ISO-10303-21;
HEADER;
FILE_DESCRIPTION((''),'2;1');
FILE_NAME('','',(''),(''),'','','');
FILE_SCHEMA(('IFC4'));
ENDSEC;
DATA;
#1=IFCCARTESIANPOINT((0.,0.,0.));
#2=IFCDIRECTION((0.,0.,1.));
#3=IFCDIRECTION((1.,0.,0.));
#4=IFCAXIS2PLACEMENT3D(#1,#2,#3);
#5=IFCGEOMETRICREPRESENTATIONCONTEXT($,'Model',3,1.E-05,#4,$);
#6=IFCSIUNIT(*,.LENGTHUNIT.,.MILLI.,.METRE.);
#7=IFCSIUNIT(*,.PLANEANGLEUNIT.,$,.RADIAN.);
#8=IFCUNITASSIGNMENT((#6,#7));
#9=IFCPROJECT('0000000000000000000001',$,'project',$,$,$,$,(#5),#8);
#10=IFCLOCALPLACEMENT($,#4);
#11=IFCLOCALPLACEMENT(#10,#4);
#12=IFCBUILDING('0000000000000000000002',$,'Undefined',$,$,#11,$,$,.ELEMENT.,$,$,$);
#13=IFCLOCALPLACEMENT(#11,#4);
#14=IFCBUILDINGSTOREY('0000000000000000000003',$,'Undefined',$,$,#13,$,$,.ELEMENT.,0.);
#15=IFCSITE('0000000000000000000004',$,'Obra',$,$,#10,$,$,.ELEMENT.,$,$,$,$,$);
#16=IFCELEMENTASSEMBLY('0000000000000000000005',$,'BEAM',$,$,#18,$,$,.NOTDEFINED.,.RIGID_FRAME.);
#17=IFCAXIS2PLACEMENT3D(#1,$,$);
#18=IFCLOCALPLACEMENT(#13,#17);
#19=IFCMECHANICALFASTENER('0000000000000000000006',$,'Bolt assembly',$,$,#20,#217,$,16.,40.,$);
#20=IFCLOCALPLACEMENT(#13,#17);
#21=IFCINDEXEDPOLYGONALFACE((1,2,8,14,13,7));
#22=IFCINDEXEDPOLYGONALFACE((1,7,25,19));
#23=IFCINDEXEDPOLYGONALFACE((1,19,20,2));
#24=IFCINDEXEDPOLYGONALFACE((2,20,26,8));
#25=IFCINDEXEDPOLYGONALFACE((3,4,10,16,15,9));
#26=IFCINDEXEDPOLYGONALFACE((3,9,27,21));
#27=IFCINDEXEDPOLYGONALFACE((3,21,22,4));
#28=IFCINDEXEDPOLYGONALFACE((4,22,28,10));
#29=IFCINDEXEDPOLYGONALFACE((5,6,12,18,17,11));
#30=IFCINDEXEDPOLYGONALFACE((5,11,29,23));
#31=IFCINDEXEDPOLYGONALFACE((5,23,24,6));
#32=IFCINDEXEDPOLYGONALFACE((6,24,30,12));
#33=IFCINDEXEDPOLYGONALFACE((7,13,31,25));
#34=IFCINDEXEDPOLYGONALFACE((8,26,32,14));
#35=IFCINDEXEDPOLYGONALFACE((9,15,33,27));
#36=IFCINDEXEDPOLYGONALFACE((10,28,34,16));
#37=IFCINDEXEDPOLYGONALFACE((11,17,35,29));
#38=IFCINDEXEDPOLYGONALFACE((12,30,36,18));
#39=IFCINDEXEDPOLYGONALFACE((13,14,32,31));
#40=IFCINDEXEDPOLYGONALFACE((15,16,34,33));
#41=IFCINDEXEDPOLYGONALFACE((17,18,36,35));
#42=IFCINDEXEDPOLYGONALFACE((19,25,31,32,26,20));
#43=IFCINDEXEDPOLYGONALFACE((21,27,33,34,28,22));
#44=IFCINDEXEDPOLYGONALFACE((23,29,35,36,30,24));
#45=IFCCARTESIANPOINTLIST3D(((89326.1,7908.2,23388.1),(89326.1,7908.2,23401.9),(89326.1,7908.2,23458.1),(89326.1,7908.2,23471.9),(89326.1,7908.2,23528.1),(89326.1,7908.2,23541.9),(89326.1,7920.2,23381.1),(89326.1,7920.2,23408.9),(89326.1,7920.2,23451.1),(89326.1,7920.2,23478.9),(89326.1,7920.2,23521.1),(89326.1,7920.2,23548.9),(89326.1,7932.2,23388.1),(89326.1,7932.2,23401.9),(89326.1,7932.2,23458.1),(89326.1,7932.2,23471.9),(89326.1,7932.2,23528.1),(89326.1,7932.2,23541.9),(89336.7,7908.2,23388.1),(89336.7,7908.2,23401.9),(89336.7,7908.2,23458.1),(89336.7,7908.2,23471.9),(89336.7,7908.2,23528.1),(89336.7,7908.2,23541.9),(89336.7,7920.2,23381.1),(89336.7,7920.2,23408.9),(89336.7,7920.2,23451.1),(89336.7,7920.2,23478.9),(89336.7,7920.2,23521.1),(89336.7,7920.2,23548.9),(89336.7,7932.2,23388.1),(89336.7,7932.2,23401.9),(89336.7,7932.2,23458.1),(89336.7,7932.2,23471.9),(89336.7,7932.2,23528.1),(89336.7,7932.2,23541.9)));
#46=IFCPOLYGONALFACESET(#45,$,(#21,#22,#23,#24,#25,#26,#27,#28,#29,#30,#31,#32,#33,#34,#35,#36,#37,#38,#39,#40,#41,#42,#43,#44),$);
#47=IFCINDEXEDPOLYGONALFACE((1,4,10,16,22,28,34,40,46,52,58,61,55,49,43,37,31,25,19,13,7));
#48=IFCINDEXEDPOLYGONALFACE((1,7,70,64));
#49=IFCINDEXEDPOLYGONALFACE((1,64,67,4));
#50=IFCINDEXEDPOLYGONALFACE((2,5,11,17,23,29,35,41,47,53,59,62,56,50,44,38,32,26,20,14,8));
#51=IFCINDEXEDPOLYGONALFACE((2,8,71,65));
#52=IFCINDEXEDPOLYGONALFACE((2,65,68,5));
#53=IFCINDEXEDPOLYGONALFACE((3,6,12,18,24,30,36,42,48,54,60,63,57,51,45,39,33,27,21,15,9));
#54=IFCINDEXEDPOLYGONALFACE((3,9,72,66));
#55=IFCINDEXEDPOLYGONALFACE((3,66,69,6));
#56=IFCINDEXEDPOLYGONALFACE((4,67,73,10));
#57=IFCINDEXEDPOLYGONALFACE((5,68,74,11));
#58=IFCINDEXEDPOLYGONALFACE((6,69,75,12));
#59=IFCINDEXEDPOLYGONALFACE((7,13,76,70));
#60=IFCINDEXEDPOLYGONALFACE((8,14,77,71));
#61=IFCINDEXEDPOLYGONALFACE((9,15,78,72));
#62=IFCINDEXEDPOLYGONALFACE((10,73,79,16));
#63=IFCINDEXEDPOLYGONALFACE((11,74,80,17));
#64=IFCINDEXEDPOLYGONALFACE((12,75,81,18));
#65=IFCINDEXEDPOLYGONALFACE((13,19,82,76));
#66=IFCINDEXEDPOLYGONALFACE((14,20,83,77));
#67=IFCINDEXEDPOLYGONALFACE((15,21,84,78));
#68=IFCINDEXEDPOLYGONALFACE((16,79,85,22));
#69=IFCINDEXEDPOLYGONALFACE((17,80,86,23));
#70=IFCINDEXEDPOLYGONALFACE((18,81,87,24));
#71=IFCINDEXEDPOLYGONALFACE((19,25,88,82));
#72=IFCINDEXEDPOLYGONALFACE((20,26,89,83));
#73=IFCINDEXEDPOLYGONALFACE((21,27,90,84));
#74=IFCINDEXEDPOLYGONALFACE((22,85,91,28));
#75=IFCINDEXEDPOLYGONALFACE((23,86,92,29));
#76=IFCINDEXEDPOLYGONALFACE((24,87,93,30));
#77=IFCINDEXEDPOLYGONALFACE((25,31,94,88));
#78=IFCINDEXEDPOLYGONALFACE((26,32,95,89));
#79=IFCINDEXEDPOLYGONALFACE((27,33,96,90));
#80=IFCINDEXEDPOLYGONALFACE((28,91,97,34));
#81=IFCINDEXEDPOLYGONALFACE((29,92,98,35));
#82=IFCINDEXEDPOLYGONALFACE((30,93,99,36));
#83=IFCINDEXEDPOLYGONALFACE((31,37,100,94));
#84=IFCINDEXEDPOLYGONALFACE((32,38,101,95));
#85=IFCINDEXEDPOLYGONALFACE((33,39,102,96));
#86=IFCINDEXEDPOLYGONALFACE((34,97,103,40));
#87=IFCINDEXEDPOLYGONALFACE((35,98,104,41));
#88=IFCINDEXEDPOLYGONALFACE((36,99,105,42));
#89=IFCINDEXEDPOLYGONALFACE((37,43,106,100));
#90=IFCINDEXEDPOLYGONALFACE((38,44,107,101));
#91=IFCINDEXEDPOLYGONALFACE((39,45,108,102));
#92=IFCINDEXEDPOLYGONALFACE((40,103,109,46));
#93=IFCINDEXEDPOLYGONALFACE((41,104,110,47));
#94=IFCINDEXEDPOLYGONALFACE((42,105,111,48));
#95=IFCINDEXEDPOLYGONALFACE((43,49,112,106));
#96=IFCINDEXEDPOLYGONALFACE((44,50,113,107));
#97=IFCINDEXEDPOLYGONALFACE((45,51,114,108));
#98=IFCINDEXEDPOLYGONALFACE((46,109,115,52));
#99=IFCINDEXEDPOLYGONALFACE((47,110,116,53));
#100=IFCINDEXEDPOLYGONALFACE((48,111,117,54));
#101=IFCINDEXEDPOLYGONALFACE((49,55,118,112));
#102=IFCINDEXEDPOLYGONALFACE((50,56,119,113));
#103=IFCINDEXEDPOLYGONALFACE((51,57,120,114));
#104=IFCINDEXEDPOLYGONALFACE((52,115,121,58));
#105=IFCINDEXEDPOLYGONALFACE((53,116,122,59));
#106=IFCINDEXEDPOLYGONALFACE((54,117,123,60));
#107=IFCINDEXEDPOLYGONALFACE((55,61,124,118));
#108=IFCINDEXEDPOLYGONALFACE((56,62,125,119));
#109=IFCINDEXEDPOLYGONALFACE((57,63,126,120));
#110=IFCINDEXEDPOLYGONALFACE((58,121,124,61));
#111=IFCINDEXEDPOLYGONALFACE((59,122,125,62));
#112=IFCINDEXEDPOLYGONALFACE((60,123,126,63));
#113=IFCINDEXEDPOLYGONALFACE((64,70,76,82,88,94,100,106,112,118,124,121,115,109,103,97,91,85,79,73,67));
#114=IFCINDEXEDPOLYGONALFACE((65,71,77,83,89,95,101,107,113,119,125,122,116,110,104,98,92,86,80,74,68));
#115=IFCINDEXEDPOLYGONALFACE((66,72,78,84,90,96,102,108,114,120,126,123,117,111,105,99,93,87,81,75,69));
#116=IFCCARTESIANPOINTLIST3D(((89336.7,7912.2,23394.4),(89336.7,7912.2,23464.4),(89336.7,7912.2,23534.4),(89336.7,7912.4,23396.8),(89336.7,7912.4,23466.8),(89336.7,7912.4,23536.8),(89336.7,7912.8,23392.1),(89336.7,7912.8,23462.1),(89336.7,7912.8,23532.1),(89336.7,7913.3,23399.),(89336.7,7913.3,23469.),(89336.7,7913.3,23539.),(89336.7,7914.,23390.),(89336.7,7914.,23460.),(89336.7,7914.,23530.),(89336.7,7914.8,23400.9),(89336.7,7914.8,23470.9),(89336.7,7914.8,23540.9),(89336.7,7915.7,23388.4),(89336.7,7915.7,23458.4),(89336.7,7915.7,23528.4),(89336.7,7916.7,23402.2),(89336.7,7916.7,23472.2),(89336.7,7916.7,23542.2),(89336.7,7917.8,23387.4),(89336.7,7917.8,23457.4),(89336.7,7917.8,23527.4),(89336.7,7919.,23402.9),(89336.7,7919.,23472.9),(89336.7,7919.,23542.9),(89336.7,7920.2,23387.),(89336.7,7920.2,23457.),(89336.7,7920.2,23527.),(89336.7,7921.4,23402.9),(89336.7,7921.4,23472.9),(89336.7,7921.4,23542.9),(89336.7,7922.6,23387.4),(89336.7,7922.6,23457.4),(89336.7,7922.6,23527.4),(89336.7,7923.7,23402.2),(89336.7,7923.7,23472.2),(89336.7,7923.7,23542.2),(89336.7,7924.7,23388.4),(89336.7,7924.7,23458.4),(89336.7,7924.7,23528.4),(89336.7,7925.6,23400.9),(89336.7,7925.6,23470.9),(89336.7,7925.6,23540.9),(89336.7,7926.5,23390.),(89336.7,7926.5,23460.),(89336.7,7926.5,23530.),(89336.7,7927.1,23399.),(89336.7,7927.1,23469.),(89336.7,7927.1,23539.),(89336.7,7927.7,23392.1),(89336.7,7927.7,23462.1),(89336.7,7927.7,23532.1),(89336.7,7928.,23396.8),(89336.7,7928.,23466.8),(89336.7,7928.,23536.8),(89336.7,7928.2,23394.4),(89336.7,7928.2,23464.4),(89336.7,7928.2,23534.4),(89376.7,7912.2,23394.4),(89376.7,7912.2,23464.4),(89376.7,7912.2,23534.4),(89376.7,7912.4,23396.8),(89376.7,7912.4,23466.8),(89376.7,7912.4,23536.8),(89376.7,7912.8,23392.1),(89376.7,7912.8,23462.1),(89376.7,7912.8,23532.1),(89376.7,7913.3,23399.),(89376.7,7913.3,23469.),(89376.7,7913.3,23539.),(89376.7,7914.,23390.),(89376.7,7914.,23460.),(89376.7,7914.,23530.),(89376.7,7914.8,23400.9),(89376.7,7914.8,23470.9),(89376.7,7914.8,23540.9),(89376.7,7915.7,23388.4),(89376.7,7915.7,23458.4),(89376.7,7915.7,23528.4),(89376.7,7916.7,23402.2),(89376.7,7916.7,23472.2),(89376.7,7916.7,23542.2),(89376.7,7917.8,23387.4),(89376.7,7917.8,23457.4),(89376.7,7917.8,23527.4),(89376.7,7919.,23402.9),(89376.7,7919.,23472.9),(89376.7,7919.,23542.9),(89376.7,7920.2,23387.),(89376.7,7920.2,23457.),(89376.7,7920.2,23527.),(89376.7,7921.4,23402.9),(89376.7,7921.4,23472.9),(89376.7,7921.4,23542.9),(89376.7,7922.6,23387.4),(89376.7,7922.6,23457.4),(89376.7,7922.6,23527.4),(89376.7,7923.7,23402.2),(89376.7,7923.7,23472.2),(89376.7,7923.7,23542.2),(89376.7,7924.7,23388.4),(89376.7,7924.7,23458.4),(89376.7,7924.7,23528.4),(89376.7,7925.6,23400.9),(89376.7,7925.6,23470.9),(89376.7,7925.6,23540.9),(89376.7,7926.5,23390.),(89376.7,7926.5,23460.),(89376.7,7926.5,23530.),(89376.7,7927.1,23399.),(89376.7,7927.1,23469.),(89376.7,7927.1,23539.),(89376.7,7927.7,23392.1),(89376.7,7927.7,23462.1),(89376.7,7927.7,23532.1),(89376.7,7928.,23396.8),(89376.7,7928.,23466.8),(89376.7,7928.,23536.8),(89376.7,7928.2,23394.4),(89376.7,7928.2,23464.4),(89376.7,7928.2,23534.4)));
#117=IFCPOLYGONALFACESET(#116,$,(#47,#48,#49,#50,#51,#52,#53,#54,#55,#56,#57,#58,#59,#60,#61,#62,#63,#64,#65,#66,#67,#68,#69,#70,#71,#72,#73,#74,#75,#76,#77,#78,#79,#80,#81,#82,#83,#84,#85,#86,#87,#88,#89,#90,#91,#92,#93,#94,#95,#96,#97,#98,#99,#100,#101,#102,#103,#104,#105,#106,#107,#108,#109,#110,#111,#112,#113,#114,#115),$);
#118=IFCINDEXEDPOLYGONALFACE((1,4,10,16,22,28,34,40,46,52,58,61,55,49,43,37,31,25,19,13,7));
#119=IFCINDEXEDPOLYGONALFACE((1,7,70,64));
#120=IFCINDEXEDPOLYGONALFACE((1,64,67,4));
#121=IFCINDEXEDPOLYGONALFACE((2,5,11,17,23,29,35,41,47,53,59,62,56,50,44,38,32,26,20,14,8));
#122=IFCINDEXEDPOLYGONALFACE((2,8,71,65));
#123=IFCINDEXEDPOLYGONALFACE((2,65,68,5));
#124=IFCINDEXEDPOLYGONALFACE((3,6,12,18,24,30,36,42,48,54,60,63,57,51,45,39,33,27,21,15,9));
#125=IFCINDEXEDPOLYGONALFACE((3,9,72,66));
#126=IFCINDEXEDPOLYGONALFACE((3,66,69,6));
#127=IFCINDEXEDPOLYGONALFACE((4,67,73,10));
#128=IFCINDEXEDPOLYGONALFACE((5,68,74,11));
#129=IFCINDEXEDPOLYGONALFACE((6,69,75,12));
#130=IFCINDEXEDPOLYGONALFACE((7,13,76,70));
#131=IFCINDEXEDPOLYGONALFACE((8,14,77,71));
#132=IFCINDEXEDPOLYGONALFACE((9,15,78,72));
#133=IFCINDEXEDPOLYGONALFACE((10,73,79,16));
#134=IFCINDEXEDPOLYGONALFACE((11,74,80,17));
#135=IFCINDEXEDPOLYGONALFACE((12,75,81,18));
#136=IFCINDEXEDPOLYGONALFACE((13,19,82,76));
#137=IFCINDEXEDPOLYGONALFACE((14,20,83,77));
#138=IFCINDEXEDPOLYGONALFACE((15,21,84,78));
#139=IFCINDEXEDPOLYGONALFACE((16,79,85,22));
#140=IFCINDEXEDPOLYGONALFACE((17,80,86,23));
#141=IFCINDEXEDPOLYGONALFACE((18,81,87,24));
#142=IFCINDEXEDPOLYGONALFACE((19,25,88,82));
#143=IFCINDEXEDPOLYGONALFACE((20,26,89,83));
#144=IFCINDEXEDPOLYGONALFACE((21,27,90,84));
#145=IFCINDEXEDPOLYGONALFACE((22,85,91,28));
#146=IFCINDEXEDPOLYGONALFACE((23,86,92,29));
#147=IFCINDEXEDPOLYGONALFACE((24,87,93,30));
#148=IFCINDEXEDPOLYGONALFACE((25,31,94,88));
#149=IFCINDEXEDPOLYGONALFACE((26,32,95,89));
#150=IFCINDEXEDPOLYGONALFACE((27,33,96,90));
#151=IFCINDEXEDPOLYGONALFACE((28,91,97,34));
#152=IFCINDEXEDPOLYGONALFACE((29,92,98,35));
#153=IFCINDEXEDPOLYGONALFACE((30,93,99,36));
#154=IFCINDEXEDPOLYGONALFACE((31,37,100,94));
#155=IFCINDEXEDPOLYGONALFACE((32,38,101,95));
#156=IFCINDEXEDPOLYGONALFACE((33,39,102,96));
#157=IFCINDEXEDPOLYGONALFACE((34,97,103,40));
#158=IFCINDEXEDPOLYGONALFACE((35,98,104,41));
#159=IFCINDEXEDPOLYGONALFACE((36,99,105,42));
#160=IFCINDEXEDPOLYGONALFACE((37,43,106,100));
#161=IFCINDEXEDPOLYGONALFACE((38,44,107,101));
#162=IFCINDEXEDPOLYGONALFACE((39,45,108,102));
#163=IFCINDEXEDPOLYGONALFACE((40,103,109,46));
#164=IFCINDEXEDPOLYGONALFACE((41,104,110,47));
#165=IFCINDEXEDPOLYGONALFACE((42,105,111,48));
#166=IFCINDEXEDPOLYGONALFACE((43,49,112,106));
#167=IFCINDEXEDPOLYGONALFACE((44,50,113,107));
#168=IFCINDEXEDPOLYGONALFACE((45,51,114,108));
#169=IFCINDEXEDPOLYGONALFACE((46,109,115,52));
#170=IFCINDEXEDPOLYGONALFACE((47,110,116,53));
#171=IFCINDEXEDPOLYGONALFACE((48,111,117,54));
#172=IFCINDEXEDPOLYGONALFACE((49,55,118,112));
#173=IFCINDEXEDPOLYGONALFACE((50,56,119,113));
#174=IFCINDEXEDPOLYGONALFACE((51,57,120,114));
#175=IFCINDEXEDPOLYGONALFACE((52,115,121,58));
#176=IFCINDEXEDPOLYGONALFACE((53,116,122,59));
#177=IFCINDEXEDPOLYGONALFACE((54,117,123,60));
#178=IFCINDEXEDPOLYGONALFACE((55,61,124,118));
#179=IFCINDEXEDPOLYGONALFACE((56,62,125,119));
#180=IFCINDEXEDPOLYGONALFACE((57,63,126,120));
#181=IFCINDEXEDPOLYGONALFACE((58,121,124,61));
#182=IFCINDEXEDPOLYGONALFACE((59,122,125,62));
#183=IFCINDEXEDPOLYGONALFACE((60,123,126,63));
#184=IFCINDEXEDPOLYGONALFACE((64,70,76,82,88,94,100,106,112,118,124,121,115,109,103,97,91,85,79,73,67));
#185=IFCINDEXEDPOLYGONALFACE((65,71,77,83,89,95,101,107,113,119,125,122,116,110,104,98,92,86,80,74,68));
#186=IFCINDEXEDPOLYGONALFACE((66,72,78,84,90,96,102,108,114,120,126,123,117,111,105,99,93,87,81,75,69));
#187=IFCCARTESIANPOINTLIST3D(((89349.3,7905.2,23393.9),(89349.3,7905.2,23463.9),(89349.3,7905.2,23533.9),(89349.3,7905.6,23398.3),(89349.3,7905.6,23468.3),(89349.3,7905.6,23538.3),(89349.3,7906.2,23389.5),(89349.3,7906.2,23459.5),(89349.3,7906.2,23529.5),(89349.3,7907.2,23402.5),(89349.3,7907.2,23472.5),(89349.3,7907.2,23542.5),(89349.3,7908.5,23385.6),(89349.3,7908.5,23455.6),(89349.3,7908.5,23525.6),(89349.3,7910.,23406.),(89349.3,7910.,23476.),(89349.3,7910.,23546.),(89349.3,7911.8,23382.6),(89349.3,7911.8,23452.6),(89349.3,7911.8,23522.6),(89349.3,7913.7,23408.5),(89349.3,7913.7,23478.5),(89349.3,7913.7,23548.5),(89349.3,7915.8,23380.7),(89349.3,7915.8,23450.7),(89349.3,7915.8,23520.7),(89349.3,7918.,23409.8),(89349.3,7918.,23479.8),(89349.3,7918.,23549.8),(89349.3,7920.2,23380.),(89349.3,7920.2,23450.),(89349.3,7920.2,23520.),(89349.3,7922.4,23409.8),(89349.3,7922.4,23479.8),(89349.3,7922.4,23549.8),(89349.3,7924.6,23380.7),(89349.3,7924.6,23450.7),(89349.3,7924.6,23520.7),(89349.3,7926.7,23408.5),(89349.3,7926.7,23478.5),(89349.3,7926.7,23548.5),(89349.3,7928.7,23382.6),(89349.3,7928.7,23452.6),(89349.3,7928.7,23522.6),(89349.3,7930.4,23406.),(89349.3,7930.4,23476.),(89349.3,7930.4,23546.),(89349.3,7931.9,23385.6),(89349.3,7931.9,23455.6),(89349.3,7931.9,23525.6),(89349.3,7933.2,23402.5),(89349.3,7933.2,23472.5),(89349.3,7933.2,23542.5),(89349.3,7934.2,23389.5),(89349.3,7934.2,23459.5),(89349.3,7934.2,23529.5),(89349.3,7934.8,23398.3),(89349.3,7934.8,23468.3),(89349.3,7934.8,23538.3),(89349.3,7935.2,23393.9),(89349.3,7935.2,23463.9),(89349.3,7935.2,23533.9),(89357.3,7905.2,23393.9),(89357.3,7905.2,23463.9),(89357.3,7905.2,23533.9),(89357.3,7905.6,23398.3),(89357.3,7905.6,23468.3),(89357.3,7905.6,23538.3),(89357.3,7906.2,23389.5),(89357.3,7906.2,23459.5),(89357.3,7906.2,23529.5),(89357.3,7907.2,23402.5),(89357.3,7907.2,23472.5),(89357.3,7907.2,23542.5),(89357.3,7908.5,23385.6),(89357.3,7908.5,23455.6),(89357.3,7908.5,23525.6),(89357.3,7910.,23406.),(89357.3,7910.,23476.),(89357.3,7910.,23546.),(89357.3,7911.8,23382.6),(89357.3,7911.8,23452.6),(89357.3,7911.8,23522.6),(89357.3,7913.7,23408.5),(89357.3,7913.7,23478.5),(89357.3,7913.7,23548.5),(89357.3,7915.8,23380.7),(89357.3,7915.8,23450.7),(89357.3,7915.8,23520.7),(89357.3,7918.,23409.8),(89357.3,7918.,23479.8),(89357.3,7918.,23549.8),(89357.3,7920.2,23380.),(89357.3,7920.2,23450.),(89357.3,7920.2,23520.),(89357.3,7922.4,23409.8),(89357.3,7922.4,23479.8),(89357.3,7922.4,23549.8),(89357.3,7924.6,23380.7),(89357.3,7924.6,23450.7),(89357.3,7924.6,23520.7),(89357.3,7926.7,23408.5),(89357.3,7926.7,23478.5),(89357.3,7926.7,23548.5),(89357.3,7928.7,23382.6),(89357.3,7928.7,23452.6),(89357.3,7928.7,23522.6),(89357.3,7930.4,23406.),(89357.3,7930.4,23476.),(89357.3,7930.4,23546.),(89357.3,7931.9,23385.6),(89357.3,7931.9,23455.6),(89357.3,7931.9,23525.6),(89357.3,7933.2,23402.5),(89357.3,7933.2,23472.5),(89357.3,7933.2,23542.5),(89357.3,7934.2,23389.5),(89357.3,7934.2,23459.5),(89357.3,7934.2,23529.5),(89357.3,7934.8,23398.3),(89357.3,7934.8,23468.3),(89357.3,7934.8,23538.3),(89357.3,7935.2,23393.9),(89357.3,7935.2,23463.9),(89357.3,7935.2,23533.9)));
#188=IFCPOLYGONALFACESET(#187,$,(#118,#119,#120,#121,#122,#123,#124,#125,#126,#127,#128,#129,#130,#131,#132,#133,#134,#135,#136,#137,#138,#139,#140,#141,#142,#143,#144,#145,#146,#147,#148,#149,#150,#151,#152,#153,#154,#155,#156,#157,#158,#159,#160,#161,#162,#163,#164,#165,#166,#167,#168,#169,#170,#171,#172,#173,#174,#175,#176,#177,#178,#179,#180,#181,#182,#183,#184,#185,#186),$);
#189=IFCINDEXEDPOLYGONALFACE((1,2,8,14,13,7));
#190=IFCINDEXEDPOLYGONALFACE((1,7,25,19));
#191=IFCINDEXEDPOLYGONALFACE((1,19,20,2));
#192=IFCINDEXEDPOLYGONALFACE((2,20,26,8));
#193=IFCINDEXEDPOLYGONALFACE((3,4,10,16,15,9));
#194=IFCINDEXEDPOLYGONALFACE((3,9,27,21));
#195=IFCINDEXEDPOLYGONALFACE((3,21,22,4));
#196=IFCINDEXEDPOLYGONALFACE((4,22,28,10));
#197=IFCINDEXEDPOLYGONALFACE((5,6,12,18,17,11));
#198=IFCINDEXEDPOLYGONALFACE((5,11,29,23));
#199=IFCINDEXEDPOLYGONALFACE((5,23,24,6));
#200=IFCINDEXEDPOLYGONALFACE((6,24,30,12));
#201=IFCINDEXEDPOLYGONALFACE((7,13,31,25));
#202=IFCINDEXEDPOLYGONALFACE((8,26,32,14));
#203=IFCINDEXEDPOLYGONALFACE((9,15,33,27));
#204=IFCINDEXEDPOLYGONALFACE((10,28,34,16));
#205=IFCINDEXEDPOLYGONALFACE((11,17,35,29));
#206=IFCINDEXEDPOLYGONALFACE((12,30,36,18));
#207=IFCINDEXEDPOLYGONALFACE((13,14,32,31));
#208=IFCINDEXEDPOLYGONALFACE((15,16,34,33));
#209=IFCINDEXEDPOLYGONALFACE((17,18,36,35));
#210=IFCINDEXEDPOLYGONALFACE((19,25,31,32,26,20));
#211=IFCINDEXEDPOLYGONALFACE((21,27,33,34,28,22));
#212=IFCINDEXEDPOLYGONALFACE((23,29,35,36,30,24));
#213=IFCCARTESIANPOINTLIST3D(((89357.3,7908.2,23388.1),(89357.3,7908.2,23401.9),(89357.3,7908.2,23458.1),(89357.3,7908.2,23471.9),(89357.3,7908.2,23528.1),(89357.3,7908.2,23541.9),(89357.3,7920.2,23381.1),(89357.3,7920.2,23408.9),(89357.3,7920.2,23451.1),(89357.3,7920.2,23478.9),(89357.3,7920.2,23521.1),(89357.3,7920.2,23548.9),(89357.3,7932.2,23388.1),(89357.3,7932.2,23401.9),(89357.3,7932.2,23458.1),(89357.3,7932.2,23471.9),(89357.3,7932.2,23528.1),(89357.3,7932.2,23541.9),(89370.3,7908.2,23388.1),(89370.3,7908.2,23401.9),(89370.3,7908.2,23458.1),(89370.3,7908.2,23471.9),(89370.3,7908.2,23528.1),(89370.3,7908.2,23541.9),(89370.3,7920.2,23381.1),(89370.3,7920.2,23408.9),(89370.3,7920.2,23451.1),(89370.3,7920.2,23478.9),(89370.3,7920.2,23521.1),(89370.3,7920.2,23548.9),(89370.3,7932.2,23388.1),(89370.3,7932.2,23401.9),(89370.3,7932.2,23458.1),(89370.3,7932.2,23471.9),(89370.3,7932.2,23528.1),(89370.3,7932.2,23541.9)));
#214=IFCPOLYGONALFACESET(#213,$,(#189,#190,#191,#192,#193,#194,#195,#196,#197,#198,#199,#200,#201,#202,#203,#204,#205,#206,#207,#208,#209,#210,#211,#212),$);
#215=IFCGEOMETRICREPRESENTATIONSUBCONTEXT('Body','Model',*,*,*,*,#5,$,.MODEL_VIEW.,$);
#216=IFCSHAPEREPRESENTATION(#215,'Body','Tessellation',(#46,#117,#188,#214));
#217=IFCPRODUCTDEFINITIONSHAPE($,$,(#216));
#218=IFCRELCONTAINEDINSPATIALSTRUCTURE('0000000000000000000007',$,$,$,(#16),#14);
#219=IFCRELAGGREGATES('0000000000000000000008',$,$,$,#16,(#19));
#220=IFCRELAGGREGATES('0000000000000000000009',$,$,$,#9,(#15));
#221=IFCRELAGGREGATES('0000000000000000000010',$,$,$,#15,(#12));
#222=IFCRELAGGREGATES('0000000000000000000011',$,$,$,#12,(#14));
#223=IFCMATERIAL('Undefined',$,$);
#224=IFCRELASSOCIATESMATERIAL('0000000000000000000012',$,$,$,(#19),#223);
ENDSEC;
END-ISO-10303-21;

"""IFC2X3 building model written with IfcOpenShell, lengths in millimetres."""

from ifc_helpers import new_model, si_unit, frame, origin_with_axes, origin_2d_with_axis, place, context, subcontext, project, spatial, polyline, circle, outline, extrude, source, transform, mapped, material, element, aggregate, save


model = new_model("IFC2X3")

# Units and contexts
model_context = context("Model", 3, precision=1e-05, world=origin_with_axes())
body_context = subcontext(model_context, "Body", "Model", "MODEL_VIEW")
ifc_project = project(units=[si_unit("LENGTHUNIT", "METRE", prefix="MILLI"), si_unit("PLANEANGLEUNIT", "RADIAN")], contexts=[model_context])

# Site, building, storey
site_placement = place(None, origin_with_axes())
site = spatial("IfcSite", under=ifc_project, at=site_placement, Name="Obra", CompositionType="ELEMENT")
building_placement = place(site_placement, origin_with_axes())
building = spatial("IfcBuilding", under=site, at=building_placement, Name="Undefined", CompositionType="ELEMENT")
storey_placement = place(building_placement, origin_with_axes())
storey = spatial("IfcBuildingStorey", under=building, at=storey_placement, Name="Undefined", CompositionType="ELEMENT", Elevation=0.0)

# Element assembly
assembly_1_placement = place(storey_placement, origin_with_axes())
assembly_1 = element("IfcElementAssembly", 1, at=assembly_1_placement, inside=storey, Name="BEAM", AssemblyPlace="NOTDEFINED", PredefinedType="RIGID_FRAME")

# Shared definitions
ifc_material_1 = material(Name="Undefined")

# Mechanical fastener
shared_shape_1 = source(origin_with_axes(), body_context, "Body", "SweptSolid", [
    extrude(outline(polyline([(13.9, 0.0), (6.9, 12.0), (-6.9, 12.0), (-13.9, 0.0), (-6.9, -12.0), (6.9, -12.0), (13.9, 0.0)])), frame((0.0, -13.9, 0.0), z_axis=(0.0, 1.0, 0.0), x_axis=(1.0, 0.0, 0.0)), (0.0, 0.0, 1.0), 10.6),
    extrude(circle(Radius=8.0, at=origin_2d_with_axis()), frame((0.0, -3.3, 0.0), z_axis=(0.0, 1.0, 0.0), x_axis=(1.0, 0.0, 0.0)), (0.0, 0.0, 1.0), 40.0),
    extrude(circle(Radius=15.0, at=origin_2d_with_axis()), frame((0.0, 9.3, 0.0), z_axis=(0.0, 1.0, 0.0), x_axis=(1.0, 0.0, 0.0)), (0.0, 0.0, 1.0), 8.0),
    extrude(outline(polyline([(13.9, 0.0), (6.9, 12.0), (-6.9, 12.0), (-13.9, 0.0), (-6.9, -12.0), (6.9, -12.0), (13.9, 0.0)])), frame((0.0, 17.3, 0.0), z_axis=(0.0, 1.0, 0.0), x_axis=(1.0, 0.0, 0.0)), (0.0, 0.0, 1.0), 13.0),
])
mechanical_fastener_1_placement = place(assembly_1_placement, frame((89340.0, 7960.2, 23570.0), z_axis=(0.0, -1.0, 0.0), x_axis=(0.0, 0.0, -1.0)))
mechanical_fastener_1 = element("IfcMechanicalFastener", 2, at=mechanical_fastener_1_placement, material=ifc_material_1, Name="Bolt assembly", NominalDiameter=16.0, NominalLength=40.0, context=body_context, shape_type="MappedRepresentation", body=[
    mapped(shared_shape_1, transform((35.0, 0.0, 40.0))),
    mapped(shared_shape_1, transform((105.0, 0.0, 40.0))),
    mapped(shared_shape_1, transform((175.0, 0.0, 40.0))),
])
aggregate(assembly_1, [mechanical_fastener_1])

save(model, "model.ifc")
